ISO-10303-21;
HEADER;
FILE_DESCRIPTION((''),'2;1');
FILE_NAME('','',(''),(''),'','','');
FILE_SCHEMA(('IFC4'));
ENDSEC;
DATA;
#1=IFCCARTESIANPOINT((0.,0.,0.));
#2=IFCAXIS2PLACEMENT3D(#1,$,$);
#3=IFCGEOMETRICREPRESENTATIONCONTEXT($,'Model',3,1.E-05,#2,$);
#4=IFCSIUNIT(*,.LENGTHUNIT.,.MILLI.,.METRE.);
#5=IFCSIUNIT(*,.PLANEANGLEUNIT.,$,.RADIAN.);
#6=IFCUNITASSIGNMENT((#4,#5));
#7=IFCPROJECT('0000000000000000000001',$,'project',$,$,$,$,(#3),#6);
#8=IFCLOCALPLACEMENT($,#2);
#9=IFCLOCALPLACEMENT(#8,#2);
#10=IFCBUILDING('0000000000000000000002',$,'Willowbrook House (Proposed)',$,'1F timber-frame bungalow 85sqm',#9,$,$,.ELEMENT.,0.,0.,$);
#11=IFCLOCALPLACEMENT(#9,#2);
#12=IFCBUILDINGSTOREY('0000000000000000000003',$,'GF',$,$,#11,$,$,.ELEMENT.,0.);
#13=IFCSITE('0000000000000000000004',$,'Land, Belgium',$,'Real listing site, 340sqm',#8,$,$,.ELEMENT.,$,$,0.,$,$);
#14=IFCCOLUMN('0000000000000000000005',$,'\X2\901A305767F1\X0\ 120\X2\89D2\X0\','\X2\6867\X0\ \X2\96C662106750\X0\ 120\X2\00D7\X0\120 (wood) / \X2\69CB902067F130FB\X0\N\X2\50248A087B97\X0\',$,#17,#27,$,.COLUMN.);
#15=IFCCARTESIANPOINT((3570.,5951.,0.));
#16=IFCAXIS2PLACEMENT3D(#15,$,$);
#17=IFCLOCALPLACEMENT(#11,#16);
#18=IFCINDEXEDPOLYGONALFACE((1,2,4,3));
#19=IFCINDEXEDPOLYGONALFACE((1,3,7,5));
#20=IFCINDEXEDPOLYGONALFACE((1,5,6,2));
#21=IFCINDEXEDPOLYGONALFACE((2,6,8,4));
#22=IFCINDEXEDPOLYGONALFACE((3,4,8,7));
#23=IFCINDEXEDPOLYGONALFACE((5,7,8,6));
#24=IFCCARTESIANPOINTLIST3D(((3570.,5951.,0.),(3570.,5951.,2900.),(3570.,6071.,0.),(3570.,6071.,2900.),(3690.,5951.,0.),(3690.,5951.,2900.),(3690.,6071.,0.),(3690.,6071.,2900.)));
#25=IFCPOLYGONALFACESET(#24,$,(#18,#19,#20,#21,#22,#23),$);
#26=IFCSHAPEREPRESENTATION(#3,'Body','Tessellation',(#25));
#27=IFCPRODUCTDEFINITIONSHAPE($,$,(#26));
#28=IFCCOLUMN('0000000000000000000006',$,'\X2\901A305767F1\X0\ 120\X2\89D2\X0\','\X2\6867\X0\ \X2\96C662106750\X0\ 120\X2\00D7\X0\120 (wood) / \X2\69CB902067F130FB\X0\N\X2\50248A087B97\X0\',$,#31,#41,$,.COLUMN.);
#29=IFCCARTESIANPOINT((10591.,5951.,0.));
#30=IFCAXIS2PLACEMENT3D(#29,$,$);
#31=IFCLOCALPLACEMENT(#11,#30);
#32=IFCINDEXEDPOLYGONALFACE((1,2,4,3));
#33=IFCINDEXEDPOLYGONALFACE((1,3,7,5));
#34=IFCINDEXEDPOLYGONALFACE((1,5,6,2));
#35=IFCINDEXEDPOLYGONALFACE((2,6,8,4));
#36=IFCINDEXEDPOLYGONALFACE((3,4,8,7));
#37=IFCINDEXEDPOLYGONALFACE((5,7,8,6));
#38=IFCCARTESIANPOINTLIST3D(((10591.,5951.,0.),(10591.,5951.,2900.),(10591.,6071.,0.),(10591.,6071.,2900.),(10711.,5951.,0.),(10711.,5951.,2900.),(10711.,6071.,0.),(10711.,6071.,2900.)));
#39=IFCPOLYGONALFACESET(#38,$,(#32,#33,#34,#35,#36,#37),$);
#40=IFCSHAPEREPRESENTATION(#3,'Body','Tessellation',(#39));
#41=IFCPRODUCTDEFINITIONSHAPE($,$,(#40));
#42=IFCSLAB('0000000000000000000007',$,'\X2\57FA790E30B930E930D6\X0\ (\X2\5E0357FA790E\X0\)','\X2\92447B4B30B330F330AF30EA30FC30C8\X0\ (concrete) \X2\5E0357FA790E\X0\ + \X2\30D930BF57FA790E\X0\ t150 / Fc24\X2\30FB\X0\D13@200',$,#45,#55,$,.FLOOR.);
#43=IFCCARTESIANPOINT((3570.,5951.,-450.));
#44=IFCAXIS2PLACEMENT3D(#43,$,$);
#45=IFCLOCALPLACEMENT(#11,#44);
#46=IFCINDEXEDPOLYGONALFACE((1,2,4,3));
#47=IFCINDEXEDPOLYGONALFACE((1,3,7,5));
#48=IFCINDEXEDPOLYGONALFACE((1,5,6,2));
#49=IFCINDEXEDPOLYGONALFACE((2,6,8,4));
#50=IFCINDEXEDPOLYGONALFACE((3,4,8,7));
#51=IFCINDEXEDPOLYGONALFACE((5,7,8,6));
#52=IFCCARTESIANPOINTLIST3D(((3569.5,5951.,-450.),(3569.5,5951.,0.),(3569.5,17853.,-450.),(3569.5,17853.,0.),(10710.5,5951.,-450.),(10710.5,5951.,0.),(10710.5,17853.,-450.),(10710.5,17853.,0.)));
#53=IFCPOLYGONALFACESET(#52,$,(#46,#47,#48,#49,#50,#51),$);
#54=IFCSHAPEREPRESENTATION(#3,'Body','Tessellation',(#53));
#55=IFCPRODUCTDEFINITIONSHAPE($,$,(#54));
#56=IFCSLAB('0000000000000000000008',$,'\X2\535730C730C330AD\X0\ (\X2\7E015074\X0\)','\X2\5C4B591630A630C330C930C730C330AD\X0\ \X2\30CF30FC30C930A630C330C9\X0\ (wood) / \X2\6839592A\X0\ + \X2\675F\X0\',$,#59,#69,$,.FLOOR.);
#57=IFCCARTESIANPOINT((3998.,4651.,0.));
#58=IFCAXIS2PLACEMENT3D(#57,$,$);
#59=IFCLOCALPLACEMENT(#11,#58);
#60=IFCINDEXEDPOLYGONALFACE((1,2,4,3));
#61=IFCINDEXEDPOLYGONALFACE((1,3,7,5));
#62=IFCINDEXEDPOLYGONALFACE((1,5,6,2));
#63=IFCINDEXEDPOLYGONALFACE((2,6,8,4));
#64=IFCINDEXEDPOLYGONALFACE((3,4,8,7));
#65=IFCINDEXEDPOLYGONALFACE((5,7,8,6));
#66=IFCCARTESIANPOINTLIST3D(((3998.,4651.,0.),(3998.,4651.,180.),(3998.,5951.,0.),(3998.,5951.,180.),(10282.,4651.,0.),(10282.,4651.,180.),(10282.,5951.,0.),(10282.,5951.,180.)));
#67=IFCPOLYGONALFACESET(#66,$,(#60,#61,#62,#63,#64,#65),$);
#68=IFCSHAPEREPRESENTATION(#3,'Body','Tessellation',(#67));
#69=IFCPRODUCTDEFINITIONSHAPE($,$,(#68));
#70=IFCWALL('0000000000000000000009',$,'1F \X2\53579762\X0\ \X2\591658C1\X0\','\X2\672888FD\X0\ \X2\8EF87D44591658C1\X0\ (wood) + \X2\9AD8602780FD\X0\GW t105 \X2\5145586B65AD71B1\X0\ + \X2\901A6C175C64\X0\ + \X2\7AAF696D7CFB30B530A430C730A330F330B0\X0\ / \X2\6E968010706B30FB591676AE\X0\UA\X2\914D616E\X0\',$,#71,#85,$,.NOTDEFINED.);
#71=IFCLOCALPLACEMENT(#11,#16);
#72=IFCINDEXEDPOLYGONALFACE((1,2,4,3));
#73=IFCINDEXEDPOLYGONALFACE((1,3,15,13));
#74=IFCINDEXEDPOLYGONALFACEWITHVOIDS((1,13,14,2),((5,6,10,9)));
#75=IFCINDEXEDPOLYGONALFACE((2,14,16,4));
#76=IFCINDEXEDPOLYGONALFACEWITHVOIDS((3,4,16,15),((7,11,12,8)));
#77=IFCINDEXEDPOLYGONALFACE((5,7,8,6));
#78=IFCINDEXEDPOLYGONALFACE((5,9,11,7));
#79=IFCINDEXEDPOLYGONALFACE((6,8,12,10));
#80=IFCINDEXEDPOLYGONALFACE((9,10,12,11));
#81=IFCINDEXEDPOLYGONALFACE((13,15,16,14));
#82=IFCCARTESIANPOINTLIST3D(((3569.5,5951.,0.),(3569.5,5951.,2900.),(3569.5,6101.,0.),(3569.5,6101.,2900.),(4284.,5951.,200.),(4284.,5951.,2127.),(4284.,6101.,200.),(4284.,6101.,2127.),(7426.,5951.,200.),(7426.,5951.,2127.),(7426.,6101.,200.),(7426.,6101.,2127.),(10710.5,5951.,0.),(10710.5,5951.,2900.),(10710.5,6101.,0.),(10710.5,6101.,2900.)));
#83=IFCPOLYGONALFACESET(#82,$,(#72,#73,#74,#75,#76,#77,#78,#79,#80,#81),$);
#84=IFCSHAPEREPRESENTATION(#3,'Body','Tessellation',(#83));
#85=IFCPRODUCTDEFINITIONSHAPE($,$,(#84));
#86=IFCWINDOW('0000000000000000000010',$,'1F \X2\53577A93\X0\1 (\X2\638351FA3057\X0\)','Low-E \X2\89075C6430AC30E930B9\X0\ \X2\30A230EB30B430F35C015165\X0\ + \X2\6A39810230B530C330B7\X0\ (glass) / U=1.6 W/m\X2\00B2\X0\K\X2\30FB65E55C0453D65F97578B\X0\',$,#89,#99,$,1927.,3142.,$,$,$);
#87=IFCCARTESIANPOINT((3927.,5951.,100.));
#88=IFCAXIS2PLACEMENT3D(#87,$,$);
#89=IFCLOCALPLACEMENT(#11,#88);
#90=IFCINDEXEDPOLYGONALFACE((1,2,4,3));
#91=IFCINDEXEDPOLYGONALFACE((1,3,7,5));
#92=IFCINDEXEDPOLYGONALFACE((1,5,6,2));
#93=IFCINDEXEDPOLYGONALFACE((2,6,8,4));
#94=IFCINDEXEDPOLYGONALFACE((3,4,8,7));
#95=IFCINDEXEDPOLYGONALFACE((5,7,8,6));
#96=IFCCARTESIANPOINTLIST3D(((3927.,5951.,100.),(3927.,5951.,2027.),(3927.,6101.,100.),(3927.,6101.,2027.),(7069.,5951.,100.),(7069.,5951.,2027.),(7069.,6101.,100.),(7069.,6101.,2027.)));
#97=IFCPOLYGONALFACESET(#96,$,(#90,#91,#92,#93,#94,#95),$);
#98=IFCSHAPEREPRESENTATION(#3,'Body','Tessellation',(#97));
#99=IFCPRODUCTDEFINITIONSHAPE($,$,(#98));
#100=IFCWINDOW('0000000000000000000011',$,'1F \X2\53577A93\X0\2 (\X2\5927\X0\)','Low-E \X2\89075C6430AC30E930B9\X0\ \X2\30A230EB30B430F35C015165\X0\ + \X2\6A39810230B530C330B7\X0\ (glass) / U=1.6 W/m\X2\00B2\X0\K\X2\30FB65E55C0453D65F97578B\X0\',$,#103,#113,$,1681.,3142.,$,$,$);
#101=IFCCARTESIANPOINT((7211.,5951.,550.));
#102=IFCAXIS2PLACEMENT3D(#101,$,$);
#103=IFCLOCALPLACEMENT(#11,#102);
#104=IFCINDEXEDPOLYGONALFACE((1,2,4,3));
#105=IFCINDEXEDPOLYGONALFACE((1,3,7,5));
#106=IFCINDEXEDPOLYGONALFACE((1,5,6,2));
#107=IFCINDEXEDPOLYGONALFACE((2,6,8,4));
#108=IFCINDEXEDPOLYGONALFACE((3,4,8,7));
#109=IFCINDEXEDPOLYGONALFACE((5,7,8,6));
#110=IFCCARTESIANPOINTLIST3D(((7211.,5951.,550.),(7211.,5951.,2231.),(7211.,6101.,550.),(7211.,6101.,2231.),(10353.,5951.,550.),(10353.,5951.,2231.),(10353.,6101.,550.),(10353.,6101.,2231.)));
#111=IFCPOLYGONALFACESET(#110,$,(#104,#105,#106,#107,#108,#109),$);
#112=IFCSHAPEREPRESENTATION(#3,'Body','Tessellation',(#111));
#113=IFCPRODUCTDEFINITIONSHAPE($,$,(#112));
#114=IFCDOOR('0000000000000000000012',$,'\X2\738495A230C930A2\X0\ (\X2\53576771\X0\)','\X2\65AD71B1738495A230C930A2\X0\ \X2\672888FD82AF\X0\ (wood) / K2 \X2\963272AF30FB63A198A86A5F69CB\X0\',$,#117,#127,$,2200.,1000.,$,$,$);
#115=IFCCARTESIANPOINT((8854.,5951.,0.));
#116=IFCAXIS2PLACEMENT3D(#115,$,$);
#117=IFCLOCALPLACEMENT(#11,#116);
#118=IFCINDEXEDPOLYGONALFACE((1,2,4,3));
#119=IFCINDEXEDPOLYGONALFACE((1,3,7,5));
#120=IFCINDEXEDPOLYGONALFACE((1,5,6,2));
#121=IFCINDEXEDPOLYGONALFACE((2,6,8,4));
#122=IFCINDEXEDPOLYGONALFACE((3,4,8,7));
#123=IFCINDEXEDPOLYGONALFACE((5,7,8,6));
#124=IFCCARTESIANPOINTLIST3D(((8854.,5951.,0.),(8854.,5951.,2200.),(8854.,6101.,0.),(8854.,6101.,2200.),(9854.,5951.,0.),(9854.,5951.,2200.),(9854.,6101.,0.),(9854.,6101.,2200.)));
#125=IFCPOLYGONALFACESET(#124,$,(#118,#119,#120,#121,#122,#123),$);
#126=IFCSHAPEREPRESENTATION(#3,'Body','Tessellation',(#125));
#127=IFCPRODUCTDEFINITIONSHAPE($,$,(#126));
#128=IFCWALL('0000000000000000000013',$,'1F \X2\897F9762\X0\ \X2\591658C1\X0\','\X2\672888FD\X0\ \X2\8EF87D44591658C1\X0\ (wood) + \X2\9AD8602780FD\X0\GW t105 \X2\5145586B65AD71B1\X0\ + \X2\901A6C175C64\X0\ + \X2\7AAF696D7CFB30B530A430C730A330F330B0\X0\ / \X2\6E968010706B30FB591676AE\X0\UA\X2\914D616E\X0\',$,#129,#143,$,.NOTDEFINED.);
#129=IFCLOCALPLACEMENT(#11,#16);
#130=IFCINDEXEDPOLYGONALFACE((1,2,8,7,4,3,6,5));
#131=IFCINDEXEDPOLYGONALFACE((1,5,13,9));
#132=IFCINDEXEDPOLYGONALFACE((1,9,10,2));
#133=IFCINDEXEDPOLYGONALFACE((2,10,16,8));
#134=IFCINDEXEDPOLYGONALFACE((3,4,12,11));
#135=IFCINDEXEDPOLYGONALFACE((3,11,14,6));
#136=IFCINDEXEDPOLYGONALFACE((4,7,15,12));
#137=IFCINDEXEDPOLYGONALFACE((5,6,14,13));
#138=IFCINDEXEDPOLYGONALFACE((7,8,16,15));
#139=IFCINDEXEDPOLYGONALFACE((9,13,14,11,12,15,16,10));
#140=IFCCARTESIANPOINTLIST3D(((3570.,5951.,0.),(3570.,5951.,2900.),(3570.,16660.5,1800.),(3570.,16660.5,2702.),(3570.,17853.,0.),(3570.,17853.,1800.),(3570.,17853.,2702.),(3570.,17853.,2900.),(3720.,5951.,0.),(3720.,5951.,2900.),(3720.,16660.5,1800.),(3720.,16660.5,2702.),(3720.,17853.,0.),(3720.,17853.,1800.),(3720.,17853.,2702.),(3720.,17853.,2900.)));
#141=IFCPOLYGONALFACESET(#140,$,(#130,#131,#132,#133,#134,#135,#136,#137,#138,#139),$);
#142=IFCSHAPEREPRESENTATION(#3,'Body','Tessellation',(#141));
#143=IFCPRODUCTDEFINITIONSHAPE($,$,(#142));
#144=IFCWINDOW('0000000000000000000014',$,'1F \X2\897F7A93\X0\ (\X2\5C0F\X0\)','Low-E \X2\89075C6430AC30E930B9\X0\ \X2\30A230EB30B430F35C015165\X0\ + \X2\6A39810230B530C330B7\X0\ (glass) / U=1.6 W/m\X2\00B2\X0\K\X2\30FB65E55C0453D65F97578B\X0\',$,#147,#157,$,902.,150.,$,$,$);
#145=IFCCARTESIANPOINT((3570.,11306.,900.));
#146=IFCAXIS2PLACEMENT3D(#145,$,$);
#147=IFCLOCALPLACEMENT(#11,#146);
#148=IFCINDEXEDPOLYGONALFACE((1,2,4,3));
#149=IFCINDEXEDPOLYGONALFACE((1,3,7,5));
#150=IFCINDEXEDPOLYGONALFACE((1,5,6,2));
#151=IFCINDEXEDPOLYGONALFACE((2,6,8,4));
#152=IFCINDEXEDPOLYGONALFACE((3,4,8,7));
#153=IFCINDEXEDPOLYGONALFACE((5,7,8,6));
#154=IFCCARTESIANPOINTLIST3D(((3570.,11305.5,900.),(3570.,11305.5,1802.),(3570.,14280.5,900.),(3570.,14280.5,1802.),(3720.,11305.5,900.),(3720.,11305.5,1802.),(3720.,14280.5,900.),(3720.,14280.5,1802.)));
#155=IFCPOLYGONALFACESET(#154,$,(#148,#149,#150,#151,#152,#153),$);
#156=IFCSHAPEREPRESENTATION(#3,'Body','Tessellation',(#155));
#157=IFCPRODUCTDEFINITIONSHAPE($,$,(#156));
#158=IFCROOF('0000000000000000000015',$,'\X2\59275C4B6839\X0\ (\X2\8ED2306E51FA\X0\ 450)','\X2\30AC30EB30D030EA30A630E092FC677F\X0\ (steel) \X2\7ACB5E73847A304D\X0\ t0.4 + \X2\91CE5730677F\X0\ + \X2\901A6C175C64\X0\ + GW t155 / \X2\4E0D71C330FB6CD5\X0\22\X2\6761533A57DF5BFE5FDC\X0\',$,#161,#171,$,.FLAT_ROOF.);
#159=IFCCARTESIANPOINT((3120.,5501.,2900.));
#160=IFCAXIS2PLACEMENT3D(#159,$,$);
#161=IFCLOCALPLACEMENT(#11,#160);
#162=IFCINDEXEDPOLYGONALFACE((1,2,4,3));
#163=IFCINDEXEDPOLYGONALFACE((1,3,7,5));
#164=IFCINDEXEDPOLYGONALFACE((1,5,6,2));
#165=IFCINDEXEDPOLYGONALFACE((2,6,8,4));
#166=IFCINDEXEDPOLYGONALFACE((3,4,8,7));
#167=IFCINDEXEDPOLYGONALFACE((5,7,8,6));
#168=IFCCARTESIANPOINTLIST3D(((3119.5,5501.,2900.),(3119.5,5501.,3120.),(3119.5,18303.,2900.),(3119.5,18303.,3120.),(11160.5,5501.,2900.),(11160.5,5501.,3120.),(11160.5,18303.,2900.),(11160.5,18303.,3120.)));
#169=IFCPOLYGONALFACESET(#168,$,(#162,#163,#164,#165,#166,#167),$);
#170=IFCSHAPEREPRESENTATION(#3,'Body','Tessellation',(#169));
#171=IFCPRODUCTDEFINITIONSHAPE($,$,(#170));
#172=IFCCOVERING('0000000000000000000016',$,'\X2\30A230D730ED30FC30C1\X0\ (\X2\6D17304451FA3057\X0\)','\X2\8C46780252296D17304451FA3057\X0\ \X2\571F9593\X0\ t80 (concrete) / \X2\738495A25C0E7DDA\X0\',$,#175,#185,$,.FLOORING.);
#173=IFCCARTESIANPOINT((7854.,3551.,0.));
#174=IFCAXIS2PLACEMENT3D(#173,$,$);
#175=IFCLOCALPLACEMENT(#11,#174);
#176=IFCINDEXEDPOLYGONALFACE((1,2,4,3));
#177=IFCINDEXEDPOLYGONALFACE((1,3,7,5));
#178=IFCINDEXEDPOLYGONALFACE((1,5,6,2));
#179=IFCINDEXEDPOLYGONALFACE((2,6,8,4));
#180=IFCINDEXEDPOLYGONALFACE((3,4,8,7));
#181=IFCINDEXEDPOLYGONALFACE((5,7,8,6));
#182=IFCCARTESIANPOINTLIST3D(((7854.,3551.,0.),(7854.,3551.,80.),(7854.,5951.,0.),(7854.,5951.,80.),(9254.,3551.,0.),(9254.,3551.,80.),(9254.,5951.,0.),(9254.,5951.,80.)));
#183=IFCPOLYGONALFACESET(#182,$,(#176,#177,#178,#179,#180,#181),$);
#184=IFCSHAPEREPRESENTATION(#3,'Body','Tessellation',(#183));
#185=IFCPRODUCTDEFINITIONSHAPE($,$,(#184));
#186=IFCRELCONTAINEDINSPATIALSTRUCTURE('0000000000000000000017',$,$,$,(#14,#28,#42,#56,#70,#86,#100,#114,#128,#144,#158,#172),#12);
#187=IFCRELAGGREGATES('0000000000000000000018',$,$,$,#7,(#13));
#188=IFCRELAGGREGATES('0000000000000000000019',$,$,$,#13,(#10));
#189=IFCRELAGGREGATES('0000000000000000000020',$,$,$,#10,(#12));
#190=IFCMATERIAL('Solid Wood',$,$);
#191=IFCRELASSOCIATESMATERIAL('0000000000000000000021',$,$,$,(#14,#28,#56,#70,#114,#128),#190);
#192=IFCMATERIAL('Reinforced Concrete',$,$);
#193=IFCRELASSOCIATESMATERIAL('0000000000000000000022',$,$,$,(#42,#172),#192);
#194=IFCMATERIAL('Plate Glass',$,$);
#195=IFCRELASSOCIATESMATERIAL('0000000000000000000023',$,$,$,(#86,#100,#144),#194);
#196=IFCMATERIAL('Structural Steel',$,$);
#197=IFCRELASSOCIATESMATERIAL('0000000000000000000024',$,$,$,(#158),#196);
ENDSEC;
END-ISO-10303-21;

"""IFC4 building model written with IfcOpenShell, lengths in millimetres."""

from ifc_helpers import new_model, si_unit, frame, frame_2d, origin, place, context, project, spatial, rectangle, extrude, material, element, fill, save


model = new_model("IFC4")

# Units and contexts
model_context = context("Model", 3, precision=1e-05, world=origin())
ifc_project = project(units=[si_unit("LENGTHUNIT", "METRE", prefix="MILLI"), si_unit("PLANEANGLEUNIT", "RADIAN")], contexts=[model_context])

# Site, building, storey
site_placement = place(None, origin())
site = spatial("IfcSite", under=ifc_project, at=site_placement, Name="Land, Belgium", ObjectType="Real listing site, 340sqm", CompositionType="ELEMENT", RefElevation=0.0)
building_placement = place(site_placement, origin())
building = spatial("IfcBuilding", under=site, at=building_placement, Name="Willowbrook House (Proposed)", ObjectType="1F timber-frame bungalow 85sqm", CompositionType="ELEMENT", ElevationOfRefHeight=0.0, ElevationOfTerrain=0.0)
storey_placement = place(building_placement, origin())
storey = spatial("IfcBuildingStorey", under=building, at=storey_placement, Name="GF", CompositionType="ELEMENT", Elevation=0.0)

# Columns
ifc_material_1 = material(Name="Solid Wood")
column_1_placement = place(storey_placement, frame((3570.0, 5951.0, 0.0)))
element("IfcColumn", 1, at=column_1_placement, inside=storey, material=ifc_material_1, Name="通し柱 120角", Description="桧 集成材 120×120 (wood) / 構造柱・N値計算", PredefinedType="COLUMN", context=model_context, shape_type="SweptSolid", body=[
    extrude(rectangle(XDim=120.0, YDim=120.0, at=frame_2d((60.0, 60.0))), frame((3570.0, 5951.0, 0.0)), (0.0, 0.0, 1.0), 2900.0),
])
column_2_placement = place(storey_placement, frame((10591.0, 5951.0, 0.0)))
element("IfcColumn", 2, at=column_2_placement, inside=storey, material=ifc_material_1, Name="通し柱 120角", Description="桧 集成材 120×120 (wood) / 構造柱・N値計算", PredefinedType="COLUMN", context=model_context, shape_type="SweptSolid", body=[
    extrude(rectangle(XDim=120.0, YDim=120.0, at=frame_2d((60.0, 60.0))), frame((10591.0, 5951.0, 0.0)), (0.0, 0.0, 1.0), 2900.0),
])

# Slabs
ifc_material_2 = material(Name="Reinforced Concrete")
slab_1_placement = place(storey_placement, frame((3570.0, 5951.0, -450.0)))
element("IfcSlab", 3, at=slab_1_placement, inside=storey, material=ifc_material_2, Name="基礎スラブ (布基礎)", Description="鉄筋コンクリート (concrete) 布基礎 + ベタ基礎 t150 / Fc24・D13@200", PredefinedType="FLOOR", context=model_context, shape_type="SweptSolid", body=[
    extrude(rectangle(XDim=7141.0, YDim=11902.0, at=frame_2d((3570.0, 5951.0))), frame((3570.0, 5951.0, -450.0)), (0.0, 0.0, 1.0), 450.0),
])
slab_2_placement = place(storey_placement, frame((3998.0, 4651.0, 0.0)))
element("IfcSlab", 4, at=slab_2_placement, inside=storey, material=ifc_material_1, Name="南デッキ (縁側)", Description="屋外ウッドデッキ ハードウッド (wood) / 根太 + 束", PredefinedType="FLOOR", context=model_context, shape_type="SweptSolid", body=[
    extrude(rectangle(XDim=6284.0, YDim=1300.0, at=frame_2d((3142.0, 650.0))), frame((3998.0, 4651.0, 0.0)), (0.0, 0.0, 1.0), 180.0),
])

# Wall, openings, windows, door
wall_1_placement = place(storey_placement, frame((3570.0, 5951.0, 0.0)))
wall_1 = element("IfcWall", 5, at=wall_1_placement, inside=storey, material=ifc_material_1, Name="1F 南面 外壁", Description="木製 軸組外壁 (wood) + 高性能GW t105 充填断熱 + 通気層 + 窯業系サイディング / 準耐火・外皮UA配慮", PredefinedType="NOTDEFINED", context=model_context, shape_type="SweptSolid", body=[
    extrude(rectangle(XDim=7141.0, YDim=150.0, at=frame_2d((3570.0, 75.0))), frame((3570.0, 5951.0, 0.0)), (0.0, 0.0, 1.0), 2900.0),
])
opening_1_placement = place(storey_placement, frame((3927.0, 5951.0, 100.0)))
opening_1 = element("IfcOpeningElement", 6, at=opening_1_placement, cuts=wall_1, PredefinedType="NOTDEFINED", context=model_context, shape_type="SweptSolid", body=[
    extrude(rectangle(XDim=3142.0, YDim=150.0, at=frame_2d((1571.0, 75.0))), frame((3927.0, 5951.0, 100.0)), (0.0, 0.0, 1.0), 1927.0),
])
opening_2_placement = place(storey_placement, frame((7211.0, 5951.0, 550.0)))
opening_2 = element("IfcOpeningElement", 7, at=opening_2_placement, cuts=wall_1, PredefinedType="NOTDEFINED", context=model_context, shape_type="SweptSolid", body=[
    extrude(rectangle(XDim=3142.0, YDim=150.0, at=frame_2d((1571.0, 75.0))), frame((7211.0, 5951.0, 550.0)), (0.0, 0.0, 1.0), 1681.0),
])
opening_3_placement = place(storey_placement, frame((8854.0, 5951.0, 0.0)))
opening_3 = element("IfcOpeningElement", 8, at=opening_3_placement, cuts=wall_1, PredefinedType="NOTDEFINED", context=model_context, shape_type="SweptSolid", body=[
    extrude(rectangle(XDim=1000.0, YDim=150.0, at=frame_2d((500.0, 75.0))), frame((8854.0, 5951.0, 0.0)), (0.0, 0.0, 1.0), 2200.0),
])
ifc_material_3 = material(Name="Plate Glass")
window_1_placement = place(storey_placement, frame((3927.0, 5951.0, 100.0)))
window_1 = element("IfcWindow", 9, at=window_1_placement, inside=storey, material=ifc_material_3, Name="1F 南窓1 (掃出し)", Description="Low-E 複層ガラス アルゴン封入 + 樹脂サッシ (glass) / U=1.6 W/m²K・日射取得型", OverallHeight=1927.0, OverallWidth=3142.0, context=model_context, shape_type="SweptSolid", body=[
    extrude(rectangle(XDim=3142.0, YDim=150.0, at=frame_2d((1571.0, 75.0))), frame((3927.0, 5951.0, 100.0)), (0.0, 0.0, 1.0), 1927.0),
])
fill(opening_1, window_1)
window_2_placement = place(storey_placement, frame((7211.0, 5951.0, 550.0)))
window_2 = element("IfcWindow", 10, at=window_2_placement, inside=storey, material=ifc_material_3, Name="1F 南窓2 (大)", Description="Low-E 複層ガラス アルゴン封入 + 樹脂サッシ (glass) / U=1.6 W/m²K・日射取得型", OverallHeight=1681.0, OverallWidth=3142.0, context=model_context, shape_type="SweptSolid", body=[
    extrude(rectangle(XDim=3142.0, YDim=150.0, at=frame_2d((1571.0, 75.0))), frame((7211.0, 5951.0, 550.0)), (0.0, 0.0, 1.0), 1681.0),
])
fill(opening_2, window_2)
door_placement = place(storey_placement, frame((8854.0, 5951.0, 0.0)))
door = element("IfcDoor", 11, at=door_placement, inside=storey, material=ifc_material_1, Name="玄関ドア (南東)", Description="断熱玄関ドア 木製芯 (wood) / K2 防犯・採風機構", OverallHeight=2200.0, OverallWidth=1000.0, context=model_context, shape_type="SweptSolid", body=[
    extrude(rectangle(XDim=1000.0, YDim=150.0, at=frame_2d((500.0, 75.0))), frame((8854.0, 5951.0, 0.0)), (0.0, 0.0, 1.0), 2200.0),
])
fill(opening_3, door)

# Wall, opening, window
wall_2_placement = place(storey_placement, frame((3570.0, 5951.0, 0.0)))
wall_2 = element("IfcWall", 12, at=wall_2_placement, inside=storey, material=ifc_material_1, Name="1F 西面 外壁", Description="木製 軸組外壁 (wood) + 高性能GW t105 充填断熱 + 通気層 + 窯業系サイディング / 準耐火・外皮UA配慮", PredefinedType="NOTDEFINED", context=model_context, shape_type="SweptSolid", body=[
    extrude(rectangle(XDim=150.0, YDim=11902.0, at=frame_2d((75.0, 5951.0))), frame((3570.0, 5951.0, 0.0)), (0.0, 0.0, 1.0), 2900.0),
])
opening_4_placement = place(storey_placement, frame((3570.0, 11306.0, 900.0)))
opening_4 = element("IfcOpeningElement", 13, at=opening_4_placement, cuts=wall_2, PredefinedType="NOTDEFINED", context=model_context, shape_type="SweptSolid", body=[
    extrude(rectangle(XDim=150.0, YDim=2975.0, at=frame_2d((75.0, 1487.0))), frame((3570.0, 11306.0, 900.0)), (0.0, 0.0, 1.0), 902.0),
])
window_3_placement = place(storey_placement, frame((3570.0, 11306.0, 900.0)))
window_3 = element("IfcWindow", 14, at=window_3_placement, inside=storey, material=ifc_material_3, Name="1F 西窓 (小)", Description="Low-E 複層ガラス アルゴン封入 + 樹脂サッシ (glass) / U=1.6 W/m²K・日射取得型", OverallHeight=902.0, OverallWidth=150.0, context=model_context, shape_type="SweptSolid", body=[
    extrude(rectangle(XDim=150.0, YDim=2975.0, at=frame_2d((75.0, 1487.0))), frame((3570.0, 11306.0, 900.0)), (0.0, 0.0, 1.0), 902.0),
])
fill(opening_4, window_3)

# Roof
ifc_material_4 = material(Name="Structural Steel")
roof_placement = place(storey_placement, frame((3120.0, 5501.0, 2900.0)))
element("IfcRoof", 15, at=roof_placement, inside=storey, material=ifc_material_4, Name="大屋根 (軒の出 450)", Description="ガルバリウム鋼板 (steel) 立平葺き t0.4 + 野地板 + 通気層 + GW t155 / 不燃・法22条区域対応", PredefinedType="FLAT_ROOF", context=model_context, shape_type="SweptSolid", body=[
    extrude(rectangle(XDim=8041.0, YDim=12802.0, at=frame_2d((4020.0, 6401.0))), frame((3120.0, 5501.0, 2900.0)), (0.0, 0.0, 1.0), 220.0),
])

# Covering
covering_1_placement = place(storey_placement, frame((7854.0, 3551.0, 0.0)))
element("IfcCovering", 16, at=covering_1_placement, inside=storey, material=ifc_material_2, Name="アプローチ (洗い出し)", Description="豆砂利洗い出し 土間 t80 (concrete) / 玄関導線", PredefinedType="FLOORING", context=model_context, shape_type="SweptSolid", body=[
    extrude(rectangle(XDim=1400.0, YDim=2400.0, at=frame_2d((700.0, 1200.0))), frame((7854.0, 3551.0, 0.0)), (0.0, 0.0, 1.0), 80.0),
])

save(model, "model.ifc")
